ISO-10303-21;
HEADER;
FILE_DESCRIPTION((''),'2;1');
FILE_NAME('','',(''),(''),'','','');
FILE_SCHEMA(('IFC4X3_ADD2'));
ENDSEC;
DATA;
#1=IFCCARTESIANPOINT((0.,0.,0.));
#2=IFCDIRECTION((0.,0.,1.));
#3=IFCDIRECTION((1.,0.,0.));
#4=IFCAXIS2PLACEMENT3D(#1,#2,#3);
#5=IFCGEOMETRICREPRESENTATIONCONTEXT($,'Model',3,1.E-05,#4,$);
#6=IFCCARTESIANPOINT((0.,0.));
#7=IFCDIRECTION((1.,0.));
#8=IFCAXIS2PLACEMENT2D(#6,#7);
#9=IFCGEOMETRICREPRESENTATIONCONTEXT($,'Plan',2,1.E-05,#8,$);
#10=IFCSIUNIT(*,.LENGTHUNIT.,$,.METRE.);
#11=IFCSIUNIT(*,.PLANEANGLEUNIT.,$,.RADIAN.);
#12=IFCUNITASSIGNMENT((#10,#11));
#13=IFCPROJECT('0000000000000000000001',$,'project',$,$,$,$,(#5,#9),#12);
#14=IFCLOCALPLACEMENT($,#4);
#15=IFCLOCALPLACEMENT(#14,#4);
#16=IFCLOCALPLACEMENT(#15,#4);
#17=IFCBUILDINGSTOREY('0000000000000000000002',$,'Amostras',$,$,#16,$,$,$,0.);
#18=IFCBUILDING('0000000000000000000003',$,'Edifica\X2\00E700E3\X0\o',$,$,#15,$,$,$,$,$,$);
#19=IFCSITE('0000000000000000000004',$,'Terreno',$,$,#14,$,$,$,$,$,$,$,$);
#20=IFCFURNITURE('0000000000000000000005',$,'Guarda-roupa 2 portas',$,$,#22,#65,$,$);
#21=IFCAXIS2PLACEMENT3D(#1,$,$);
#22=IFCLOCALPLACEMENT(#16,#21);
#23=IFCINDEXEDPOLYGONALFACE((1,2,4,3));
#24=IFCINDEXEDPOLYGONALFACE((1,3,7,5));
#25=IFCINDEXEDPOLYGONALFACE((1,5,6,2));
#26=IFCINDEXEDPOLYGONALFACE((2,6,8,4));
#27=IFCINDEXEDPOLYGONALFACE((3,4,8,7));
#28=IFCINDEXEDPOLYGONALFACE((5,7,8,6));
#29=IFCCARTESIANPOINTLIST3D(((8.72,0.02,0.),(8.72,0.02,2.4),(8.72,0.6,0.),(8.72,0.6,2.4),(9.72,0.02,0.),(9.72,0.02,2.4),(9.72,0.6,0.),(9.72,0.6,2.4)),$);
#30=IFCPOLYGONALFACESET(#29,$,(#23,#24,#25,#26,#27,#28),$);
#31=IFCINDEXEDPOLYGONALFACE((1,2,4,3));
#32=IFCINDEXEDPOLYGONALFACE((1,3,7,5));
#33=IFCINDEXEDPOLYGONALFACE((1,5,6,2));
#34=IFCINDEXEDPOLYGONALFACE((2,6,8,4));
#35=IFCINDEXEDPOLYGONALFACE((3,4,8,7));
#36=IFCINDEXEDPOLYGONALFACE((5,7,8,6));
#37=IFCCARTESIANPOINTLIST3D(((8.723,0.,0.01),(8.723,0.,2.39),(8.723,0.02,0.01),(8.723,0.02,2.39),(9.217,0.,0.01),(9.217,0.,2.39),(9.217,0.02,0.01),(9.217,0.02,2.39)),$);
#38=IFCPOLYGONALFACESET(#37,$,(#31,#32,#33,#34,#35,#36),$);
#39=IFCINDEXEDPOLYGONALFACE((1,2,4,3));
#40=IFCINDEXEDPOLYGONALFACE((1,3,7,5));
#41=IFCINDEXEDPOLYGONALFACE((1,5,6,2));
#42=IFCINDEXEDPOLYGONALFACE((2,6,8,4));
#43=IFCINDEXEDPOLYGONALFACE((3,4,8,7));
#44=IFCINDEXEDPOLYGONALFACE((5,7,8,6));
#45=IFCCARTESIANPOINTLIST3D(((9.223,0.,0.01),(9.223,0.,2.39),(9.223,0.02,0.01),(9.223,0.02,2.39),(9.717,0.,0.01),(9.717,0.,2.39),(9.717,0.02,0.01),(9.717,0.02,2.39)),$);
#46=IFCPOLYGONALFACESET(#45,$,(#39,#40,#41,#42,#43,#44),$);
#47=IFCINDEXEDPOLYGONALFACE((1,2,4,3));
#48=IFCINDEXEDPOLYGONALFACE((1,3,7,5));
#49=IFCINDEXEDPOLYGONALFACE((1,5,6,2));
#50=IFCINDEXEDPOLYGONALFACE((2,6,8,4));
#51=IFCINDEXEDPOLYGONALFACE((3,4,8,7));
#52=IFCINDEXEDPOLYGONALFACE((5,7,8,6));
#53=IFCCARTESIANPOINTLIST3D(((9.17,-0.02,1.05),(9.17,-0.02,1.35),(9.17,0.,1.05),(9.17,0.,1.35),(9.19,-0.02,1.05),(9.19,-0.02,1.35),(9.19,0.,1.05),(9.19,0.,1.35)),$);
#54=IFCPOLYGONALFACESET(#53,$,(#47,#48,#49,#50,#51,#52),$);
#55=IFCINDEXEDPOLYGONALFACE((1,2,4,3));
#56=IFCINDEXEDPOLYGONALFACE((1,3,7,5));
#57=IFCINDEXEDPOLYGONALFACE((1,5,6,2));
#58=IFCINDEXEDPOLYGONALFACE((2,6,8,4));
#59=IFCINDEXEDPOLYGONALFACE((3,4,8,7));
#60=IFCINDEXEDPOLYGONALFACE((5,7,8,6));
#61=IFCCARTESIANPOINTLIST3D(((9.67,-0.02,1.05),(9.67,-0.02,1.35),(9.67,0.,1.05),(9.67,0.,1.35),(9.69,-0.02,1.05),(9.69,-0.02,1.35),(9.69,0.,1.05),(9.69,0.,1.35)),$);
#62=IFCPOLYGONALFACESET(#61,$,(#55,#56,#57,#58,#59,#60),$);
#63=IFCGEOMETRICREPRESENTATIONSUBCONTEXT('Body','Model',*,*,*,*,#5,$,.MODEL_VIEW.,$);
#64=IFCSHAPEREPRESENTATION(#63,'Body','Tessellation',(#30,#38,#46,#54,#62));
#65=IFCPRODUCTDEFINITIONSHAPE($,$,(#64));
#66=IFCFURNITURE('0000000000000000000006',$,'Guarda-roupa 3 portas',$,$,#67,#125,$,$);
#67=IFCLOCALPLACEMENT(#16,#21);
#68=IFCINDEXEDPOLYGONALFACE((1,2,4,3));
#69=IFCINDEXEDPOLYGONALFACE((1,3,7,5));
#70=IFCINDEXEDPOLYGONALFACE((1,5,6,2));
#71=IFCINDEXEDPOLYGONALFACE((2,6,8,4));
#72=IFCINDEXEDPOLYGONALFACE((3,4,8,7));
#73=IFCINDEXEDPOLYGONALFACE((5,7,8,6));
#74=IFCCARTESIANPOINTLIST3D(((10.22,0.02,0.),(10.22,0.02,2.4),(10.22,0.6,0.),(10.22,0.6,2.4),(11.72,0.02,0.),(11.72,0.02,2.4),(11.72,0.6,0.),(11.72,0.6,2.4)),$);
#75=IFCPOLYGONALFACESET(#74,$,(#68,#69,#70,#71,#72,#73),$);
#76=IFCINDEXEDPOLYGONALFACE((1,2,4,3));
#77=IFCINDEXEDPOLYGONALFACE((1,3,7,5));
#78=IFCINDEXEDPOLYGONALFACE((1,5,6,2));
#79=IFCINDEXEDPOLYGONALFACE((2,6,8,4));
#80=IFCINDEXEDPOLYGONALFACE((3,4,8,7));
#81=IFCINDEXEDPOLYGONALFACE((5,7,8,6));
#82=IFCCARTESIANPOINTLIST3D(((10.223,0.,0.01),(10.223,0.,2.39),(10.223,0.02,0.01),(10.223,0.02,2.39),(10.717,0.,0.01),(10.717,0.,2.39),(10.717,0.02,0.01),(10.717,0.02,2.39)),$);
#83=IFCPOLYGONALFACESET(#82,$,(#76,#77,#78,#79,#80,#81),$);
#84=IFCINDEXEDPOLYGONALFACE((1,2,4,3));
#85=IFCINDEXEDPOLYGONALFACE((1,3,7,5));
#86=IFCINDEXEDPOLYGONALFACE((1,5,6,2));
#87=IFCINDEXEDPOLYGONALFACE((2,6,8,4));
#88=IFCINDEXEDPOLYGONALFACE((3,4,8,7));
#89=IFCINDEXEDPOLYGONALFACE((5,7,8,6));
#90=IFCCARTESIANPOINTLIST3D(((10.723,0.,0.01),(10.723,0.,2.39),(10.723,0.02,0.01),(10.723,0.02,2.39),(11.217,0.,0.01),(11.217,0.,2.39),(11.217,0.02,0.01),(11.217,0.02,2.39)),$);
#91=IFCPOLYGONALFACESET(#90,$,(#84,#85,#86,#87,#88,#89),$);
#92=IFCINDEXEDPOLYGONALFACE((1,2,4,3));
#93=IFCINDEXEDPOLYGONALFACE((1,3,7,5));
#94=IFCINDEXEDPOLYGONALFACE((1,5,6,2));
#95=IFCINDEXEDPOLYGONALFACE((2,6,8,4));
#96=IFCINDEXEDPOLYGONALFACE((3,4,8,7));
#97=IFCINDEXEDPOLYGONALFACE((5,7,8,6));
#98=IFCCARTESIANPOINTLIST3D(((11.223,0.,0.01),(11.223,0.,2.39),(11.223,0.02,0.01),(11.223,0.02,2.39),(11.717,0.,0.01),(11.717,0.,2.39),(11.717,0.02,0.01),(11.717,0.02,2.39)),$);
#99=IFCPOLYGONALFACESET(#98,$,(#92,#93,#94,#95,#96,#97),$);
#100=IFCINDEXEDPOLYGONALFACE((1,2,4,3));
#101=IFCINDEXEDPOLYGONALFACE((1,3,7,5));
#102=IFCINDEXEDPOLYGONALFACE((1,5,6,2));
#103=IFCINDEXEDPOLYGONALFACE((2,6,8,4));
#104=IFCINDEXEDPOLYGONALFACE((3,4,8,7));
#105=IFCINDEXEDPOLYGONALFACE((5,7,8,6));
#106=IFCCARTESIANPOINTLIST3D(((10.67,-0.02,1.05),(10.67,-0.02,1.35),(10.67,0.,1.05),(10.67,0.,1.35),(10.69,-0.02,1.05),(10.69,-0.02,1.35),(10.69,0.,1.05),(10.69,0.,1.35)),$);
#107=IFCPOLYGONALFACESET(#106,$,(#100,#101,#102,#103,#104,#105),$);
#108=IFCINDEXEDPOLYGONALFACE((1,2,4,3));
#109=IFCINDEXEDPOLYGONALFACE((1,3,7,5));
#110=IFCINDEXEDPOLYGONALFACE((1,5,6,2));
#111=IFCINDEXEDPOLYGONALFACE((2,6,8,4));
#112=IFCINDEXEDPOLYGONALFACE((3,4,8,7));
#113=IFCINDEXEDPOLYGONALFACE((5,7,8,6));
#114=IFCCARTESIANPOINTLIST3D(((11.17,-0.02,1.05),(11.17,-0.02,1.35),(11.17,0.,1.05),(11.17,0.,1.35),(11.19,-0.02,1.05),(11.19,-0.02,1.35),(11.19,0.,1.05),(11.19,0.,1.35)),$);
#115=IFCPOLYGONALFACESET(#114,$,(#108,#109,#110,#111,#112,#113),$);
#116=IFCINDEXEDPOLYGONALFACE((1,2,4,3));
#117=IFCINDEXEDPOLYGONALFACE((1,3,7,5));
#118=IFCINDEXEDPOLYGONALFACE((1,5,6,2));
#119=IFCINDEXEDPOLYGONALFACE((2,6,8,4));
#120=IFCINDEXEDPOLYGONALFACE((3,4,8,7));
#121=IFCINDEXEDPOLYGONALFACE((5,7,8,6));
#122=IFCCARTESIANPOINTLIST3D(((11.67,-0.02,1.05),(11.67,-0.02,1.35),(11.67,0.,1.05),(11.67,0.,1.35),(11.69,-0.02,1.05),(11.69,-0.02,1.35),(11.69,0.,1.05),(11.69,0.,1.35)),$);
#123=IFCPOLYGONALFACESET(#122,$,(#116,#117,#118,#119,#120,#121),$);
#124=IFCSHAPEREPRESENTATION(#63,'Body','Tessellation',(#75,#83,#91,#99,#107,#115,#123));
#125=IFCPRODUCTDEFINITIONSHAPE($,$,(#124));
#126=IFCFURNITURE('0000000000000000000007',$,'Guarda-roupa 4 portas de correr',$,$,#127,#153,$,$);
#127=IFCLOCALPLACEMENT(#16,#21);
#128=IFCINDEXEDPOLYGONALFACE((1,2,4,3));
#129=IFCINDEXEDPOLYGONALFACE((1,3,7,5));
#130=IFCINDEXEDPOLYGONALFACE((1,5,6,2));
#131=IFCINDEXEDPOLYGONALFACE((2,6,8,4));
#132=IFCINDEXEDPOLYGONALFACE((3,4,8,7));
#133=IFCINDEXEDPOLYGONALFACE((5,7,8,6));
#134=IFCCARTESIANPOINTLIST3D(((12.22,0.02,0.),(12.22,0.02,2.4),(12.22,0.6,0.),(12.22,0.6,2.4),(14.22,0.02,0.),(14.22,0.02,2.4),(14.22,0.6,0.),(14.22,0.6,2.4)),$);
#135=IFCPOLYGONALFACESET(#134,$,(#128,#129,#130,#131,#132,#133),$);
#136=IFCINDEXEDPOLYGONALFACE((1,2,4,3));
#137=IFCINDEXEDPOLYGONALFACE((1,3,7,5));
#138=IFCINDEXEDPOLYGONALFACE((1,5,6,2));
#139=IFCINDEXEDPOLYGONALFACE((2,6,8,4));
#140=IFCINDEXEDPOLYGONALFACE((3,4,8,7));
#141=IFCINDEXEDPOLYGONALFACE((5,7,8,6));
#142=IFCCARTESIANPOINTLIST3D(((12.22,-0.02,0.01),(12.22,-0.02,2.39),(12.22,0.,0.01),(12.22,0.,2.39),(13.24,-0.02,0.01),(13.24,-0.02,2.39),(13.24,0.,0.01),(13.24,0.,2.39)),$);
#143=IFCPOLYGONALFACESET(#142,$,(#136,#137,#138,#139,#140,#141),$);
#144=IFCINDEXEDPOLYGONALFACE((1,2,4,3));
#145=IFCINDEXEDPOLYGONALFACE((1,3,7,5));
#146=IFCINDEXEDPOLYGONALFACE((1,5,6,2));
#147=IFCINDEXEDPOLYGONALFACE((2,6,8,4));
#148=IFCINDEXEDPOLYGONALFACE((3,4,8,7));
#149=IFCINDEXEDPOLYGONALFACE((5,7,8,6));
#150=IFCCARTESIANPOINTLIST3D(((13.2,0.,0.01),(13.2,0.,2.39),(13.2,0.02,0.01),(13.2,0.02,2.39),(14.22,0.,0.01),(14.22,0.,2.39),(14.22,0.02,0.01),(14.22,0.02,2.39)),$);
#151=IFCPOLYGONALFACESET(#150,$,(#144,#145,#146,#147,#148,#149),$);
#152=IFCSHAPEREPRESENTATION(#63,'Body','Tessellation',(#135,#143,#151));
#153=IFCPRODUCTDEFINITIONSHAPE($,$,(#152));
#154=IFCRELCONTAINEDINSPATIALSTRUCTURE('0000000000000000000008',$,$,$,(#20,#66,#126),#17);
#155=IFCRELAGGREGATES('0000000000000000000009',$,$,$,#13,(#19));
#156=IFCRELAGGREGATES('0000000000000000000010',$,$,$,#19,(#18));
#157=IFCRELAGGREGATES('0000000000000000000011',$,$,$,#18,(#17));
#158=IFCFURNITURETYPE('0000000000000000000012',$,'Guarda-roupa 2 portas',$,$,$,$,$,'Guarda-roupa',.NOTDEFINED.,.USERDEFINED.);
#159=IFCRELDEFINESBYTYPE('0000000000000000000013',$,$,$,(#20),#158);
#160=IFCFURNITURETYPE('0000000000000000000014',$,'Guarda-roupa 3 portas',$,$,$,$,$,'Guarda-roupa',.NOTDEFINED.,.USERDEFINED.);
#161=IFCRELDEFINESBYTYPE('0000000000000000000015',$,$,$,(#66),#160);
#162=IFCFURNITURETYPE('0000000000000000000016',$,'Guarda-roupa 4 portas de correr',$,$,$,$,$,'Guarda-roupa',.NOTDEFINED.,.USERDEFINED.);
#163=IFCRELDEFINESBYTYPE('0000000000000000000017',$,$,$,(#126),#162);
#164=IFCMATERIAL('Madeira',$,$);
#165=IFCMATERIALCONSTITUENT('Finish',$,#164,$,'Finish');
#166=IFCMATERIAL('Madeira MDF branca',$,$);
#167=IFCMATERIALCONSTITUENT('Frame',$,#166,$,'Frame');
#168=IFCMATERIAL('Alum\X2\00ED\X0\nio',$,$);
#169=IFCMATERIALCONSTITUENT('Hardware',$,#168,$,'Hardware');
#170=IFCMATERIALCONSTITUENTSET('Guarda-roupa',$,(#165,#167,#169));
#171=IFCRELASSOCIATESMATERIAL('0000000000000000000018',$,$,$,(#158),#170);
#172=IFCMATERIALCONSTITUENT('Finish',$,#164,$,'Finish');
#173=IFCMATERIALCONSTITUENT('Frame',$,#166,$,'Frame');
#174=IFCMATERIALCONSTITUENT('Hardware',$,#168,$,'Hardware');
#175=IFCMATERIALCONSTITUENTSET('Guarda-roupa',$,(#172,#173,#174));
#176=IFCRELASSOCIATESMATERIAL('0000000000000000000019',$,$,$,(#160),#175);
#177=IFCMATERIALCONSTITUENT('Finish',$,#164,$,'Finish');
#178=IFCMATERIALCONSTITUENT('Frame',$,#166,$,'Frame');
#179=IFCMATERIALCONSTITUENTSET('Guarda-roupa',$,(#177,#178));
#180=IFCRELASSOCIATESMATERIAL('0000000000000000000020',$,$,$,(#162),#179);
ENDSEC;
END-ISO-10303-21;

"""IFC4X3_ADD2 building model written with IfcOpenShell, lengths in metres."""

from ifc_helpers import new_model, si_unit, frame, frame_2d, origin, origin_with_axes, origin_2d_with_axis, place, context, subcontext, project, spatial, rectangle, extrude, material, constituent, constituent_set, type_object, element, save


model = new_model("IFC4X3_ADD2")

# Units and contexts
model_context = context("Model", 3, precision=1e-05, world=origin_with_axes())
plan_context = context("Plan", 2, precision=1e-05, world=origin_2d_with_axis())
body_context = subcontext(model_context, "Body", "Model", "MODEL_VIEW")
ifc_project = project(units=[si_unit("LENGTHUNIT", "METRE"), si_unit("PLANEANGLEUNIT", "RADIAN")], contexts=[model_context, plan_context])

# Site, building, storey
site_placement = place(None, origin_with_axes())
site = spatial("IfcSite", under=ifc_project, at=site_placement, Name="Terreno")
building_placement = place(site_placement, origin_with_axes())
building = spatial("IfcBuilding", under=site, at=building_placement, Name="Edificação")
storey_placement = place(building_placement, origin_with_axes())
storey = spatial("IfcBuildingStorey", under=building, at=storey_placement, Name="Amostras", Elevation=0.0)

# Furniture
ifc_material_1 = material(Name="Madeira")
ifc_material_2 = material(Name="Madeira MDF branca")
ifc_constituent_1 = constituent(ifc_material_1, Name="Finish", Category="Finish")
ifc_constituent_2 = constituent(ifc_material_2, Name="Frame", Category="Frame")
ifc_material_3 = material(Name="Alumínio")
ifc_constituent_3 = constituent(ifc_material_3, Name="Hardware", Category="Hardware")
ifc_constituent_set_1 = constituent_set(constituents=[ifc_constituent_1, ifc_constituent_2, ifc_constituent_3], Name="Guarda-roupa")
furniture_type_1 = type_object("IfcFurnitureType", Name="Guarda-roupa 2 portas", ElementType="Guarda-roupa", AssemblyPlace="NOTDEFINED", PredefinedType="USERDEFINED", material=ifc_constituent_set_1)
furniture_1_placement = place(storey_placement, frame((8.72, 0.0, 0.0), z_axis=(0.0, 0.0, 1.0), x_axis=(1.0, 0.0, 0.0)))
element("IfcFurniture", 1, at=furniture_1_placement, inside=storey, type_object=furniture_type_1, Name="Guarda-roupa 2 portas", context=body_context, shape_type="SweptSolid", body=[
    extrude(rectangle(XDim=1.0, YDim=0.58, at=frame_2d((0.5, 0.31), x_axis=(1.0, 0.0))), origin(), (0.0, 0.0, 1.0), 2.4),
    extrude(rectangle(XDim=0.494, YDim=0.02, at=frame_2d((0.25, 0.01), x_axis=(1.0, 0.0))), frame((0.0, 0.0, 0.01)), (0.0, 0.0, 1.0), 2.38),
    extrude(rectangle(XDim=0.494, YDim=0.02, at=frame_2d((0.75, 0.01), x_axis=(1.0, 0.0))), frame((0.0, 0.0, 0.01)), (0.0, 0.0, 1.0), 2.38),
    extrude(rectangle(XDim=0.02, YDim=0.02, at=frame_2d((0.46, -0.01), x_axis=(1.0, 0.0))), frame((0.0, 0.0, 1.05)), (0.0, 0.0, 1.0), 0.3),
    extrude(rectangle(XDim=0.02, YDim=0.02, at=frame_2d((0.96, -0.01), x_axis=(1.0, 0.0))), frame((0.0, 0.0, 1.05)), (0.0, 0.0, 1.0), 0.3),
])
ifc_constituent_4 = constituent(ifc_material_1, Name="Finish", Category="Finish")
ifc_constituent_5 = constituent(ifc_material_2, Name="Frame", Category="Frame")
ifc_constituent_6 = constituent(ifc_material_3, Name="Hardware", Category="Hardware")
ifc_constituent_set_2 = constituent_set(constituents=[ifc_constituent_4, ifc_constituent_5, ifc_constituent_6], Name="Guarda-roupa")
furniture_type_2 = type_object("IfcFurnitureType", Name="Guarda-roupa 3 portas", ElementType="Guarda-roupa", AssemblyPlace="NOTDEFINED", PredefinedType="USERDEFINED", material=ifc_constituent_set_2)
furniture_2_placement = place(storey_placement, frame((10.22, 0.0, 0.0), z_axis=(0.0, 0.0, 1.0), x_axis=(1.0, 0.0, 0.0)))
element("IfcFurniture", 2, at=furniture_2_placement, inside=storey, type_object=furniture_type_2, Name="Guarda-roupa 3 portas", context=body_context, shape_type="SweptSolid", body=[
    extrude(rectangle(XDim=1.5, YDim=0.58, at=frame_2d((0.75, 0.31), x_axis=(1.0, 0.0))), origin(), (0.0, 0.0, 1.0), 2.4),
    extrude(rectangle(XDim=0.494, YDim=0.02, at=frame_2d((0.25, 0.01), x_axis=(1.0, 0.0))), frame((0.0, 0.0, 0.01)), (0.0, 0.0, 1.0), 2.38),
    extrude(rectangle(XDim=0.494, YDim=0.02, at=frame_2d((0.75, 0.01), x_axis=(1.0, 0.0))), frame((0.0, 0.0, 0.01)), (0.0, 0.0, 1.0), 2.38),
    extrude(rectangle(XDim=0.494, YDim=0.02, at=frame_2d((1.25, 0.01), x_axis=(1.0, 0.0))), frame((0.0, 0.0, 0.01)), (0.0, 0.0, 1.0), 2.38),
    extrude(rectangle(XDim=0.02, YDim=0.02, at=frame_2d((0.46, -0.01), x_axis=(1.0, 0.0))), frame((0.0, 0.0, 1.05)), (0.0, 0.0, 1.0), 0.3),
    extrude(rectangle(XDim=0.02, YDim=0.02, at=frame_2d((0.96, -0.01), x_axis=(1.0, 0.0))), frame((0.0, 0.0, 1.05)), (0.0, 0.0, 1.0), 0.3),
    extrude(rectangle(XDim=0.02, YDim=0.02, at=frame_2d((1.46, -0.01), x_axis=(1.0, 0.0))), frame((0.0, 0.0, 1.05)), (0.0, 0.0, 1.0), 0.3),
])
ifc_constituent_7 = constituent(ifc_material_1, Name="Finish", Category="Finish")
ifc_constituent_8 = constituent(ifc_material_2, Name="Frame", Category="Frame")
ifc_constituent_set_3 = constituent_set(constituents=[ifc_constituent_7, ifc_constituent_8], Name="Guarda-roupa")
furniture_type_3 = type_object("IfcFurnitureType", Name="Guarda-roupa 4 portas de correr", ElementType="Guarda-roupa", AssemblyPlace="NOTDEFINED", PredefinedType="USERDEFINED", material=ifc_constituent_set_3)
furniture_3_placement = place(storey_placement, frame((12.22, 0.0, 0.0), z_axis=(0.0, 0.0, 1.0), x_axis=(1.0, 0.0, 0.0)))
element("IfcFurniture", 3, at=furniture_3_placement, inside=storey, type_object=furniture_type_3, Name="Guarda-roupa 4 portas de correr", context=body_context, shape_type="SweptSolid", body=[
    extrude(rectangle(XDim=2.0, YDim=0.58, at=frame_2d((1.0, 0.31), x_axis=(1.0, 0.0))), origin(), (0.0, 0.0, 1.0), 2.4),
    extrude(rectangle(XDim=1.02, YDim=0.02, at=frame_2d((0.51, -0.01), x_axis=(1.0, 0.0))), frame((0.0, 0.0, 0.01)), (0.0, 0.0, 1.0), 2.38),
    extrude(rectangle(XDim=1.02, YDim=0.02, at=frame_2d((1.49, 0.01), x_axis=(1.0, 0.0))), frame((0.0, 0.0, 0.01)), (0.0, 0.0, 1.0), 2.38),
])

save(model, "model.ifc")
